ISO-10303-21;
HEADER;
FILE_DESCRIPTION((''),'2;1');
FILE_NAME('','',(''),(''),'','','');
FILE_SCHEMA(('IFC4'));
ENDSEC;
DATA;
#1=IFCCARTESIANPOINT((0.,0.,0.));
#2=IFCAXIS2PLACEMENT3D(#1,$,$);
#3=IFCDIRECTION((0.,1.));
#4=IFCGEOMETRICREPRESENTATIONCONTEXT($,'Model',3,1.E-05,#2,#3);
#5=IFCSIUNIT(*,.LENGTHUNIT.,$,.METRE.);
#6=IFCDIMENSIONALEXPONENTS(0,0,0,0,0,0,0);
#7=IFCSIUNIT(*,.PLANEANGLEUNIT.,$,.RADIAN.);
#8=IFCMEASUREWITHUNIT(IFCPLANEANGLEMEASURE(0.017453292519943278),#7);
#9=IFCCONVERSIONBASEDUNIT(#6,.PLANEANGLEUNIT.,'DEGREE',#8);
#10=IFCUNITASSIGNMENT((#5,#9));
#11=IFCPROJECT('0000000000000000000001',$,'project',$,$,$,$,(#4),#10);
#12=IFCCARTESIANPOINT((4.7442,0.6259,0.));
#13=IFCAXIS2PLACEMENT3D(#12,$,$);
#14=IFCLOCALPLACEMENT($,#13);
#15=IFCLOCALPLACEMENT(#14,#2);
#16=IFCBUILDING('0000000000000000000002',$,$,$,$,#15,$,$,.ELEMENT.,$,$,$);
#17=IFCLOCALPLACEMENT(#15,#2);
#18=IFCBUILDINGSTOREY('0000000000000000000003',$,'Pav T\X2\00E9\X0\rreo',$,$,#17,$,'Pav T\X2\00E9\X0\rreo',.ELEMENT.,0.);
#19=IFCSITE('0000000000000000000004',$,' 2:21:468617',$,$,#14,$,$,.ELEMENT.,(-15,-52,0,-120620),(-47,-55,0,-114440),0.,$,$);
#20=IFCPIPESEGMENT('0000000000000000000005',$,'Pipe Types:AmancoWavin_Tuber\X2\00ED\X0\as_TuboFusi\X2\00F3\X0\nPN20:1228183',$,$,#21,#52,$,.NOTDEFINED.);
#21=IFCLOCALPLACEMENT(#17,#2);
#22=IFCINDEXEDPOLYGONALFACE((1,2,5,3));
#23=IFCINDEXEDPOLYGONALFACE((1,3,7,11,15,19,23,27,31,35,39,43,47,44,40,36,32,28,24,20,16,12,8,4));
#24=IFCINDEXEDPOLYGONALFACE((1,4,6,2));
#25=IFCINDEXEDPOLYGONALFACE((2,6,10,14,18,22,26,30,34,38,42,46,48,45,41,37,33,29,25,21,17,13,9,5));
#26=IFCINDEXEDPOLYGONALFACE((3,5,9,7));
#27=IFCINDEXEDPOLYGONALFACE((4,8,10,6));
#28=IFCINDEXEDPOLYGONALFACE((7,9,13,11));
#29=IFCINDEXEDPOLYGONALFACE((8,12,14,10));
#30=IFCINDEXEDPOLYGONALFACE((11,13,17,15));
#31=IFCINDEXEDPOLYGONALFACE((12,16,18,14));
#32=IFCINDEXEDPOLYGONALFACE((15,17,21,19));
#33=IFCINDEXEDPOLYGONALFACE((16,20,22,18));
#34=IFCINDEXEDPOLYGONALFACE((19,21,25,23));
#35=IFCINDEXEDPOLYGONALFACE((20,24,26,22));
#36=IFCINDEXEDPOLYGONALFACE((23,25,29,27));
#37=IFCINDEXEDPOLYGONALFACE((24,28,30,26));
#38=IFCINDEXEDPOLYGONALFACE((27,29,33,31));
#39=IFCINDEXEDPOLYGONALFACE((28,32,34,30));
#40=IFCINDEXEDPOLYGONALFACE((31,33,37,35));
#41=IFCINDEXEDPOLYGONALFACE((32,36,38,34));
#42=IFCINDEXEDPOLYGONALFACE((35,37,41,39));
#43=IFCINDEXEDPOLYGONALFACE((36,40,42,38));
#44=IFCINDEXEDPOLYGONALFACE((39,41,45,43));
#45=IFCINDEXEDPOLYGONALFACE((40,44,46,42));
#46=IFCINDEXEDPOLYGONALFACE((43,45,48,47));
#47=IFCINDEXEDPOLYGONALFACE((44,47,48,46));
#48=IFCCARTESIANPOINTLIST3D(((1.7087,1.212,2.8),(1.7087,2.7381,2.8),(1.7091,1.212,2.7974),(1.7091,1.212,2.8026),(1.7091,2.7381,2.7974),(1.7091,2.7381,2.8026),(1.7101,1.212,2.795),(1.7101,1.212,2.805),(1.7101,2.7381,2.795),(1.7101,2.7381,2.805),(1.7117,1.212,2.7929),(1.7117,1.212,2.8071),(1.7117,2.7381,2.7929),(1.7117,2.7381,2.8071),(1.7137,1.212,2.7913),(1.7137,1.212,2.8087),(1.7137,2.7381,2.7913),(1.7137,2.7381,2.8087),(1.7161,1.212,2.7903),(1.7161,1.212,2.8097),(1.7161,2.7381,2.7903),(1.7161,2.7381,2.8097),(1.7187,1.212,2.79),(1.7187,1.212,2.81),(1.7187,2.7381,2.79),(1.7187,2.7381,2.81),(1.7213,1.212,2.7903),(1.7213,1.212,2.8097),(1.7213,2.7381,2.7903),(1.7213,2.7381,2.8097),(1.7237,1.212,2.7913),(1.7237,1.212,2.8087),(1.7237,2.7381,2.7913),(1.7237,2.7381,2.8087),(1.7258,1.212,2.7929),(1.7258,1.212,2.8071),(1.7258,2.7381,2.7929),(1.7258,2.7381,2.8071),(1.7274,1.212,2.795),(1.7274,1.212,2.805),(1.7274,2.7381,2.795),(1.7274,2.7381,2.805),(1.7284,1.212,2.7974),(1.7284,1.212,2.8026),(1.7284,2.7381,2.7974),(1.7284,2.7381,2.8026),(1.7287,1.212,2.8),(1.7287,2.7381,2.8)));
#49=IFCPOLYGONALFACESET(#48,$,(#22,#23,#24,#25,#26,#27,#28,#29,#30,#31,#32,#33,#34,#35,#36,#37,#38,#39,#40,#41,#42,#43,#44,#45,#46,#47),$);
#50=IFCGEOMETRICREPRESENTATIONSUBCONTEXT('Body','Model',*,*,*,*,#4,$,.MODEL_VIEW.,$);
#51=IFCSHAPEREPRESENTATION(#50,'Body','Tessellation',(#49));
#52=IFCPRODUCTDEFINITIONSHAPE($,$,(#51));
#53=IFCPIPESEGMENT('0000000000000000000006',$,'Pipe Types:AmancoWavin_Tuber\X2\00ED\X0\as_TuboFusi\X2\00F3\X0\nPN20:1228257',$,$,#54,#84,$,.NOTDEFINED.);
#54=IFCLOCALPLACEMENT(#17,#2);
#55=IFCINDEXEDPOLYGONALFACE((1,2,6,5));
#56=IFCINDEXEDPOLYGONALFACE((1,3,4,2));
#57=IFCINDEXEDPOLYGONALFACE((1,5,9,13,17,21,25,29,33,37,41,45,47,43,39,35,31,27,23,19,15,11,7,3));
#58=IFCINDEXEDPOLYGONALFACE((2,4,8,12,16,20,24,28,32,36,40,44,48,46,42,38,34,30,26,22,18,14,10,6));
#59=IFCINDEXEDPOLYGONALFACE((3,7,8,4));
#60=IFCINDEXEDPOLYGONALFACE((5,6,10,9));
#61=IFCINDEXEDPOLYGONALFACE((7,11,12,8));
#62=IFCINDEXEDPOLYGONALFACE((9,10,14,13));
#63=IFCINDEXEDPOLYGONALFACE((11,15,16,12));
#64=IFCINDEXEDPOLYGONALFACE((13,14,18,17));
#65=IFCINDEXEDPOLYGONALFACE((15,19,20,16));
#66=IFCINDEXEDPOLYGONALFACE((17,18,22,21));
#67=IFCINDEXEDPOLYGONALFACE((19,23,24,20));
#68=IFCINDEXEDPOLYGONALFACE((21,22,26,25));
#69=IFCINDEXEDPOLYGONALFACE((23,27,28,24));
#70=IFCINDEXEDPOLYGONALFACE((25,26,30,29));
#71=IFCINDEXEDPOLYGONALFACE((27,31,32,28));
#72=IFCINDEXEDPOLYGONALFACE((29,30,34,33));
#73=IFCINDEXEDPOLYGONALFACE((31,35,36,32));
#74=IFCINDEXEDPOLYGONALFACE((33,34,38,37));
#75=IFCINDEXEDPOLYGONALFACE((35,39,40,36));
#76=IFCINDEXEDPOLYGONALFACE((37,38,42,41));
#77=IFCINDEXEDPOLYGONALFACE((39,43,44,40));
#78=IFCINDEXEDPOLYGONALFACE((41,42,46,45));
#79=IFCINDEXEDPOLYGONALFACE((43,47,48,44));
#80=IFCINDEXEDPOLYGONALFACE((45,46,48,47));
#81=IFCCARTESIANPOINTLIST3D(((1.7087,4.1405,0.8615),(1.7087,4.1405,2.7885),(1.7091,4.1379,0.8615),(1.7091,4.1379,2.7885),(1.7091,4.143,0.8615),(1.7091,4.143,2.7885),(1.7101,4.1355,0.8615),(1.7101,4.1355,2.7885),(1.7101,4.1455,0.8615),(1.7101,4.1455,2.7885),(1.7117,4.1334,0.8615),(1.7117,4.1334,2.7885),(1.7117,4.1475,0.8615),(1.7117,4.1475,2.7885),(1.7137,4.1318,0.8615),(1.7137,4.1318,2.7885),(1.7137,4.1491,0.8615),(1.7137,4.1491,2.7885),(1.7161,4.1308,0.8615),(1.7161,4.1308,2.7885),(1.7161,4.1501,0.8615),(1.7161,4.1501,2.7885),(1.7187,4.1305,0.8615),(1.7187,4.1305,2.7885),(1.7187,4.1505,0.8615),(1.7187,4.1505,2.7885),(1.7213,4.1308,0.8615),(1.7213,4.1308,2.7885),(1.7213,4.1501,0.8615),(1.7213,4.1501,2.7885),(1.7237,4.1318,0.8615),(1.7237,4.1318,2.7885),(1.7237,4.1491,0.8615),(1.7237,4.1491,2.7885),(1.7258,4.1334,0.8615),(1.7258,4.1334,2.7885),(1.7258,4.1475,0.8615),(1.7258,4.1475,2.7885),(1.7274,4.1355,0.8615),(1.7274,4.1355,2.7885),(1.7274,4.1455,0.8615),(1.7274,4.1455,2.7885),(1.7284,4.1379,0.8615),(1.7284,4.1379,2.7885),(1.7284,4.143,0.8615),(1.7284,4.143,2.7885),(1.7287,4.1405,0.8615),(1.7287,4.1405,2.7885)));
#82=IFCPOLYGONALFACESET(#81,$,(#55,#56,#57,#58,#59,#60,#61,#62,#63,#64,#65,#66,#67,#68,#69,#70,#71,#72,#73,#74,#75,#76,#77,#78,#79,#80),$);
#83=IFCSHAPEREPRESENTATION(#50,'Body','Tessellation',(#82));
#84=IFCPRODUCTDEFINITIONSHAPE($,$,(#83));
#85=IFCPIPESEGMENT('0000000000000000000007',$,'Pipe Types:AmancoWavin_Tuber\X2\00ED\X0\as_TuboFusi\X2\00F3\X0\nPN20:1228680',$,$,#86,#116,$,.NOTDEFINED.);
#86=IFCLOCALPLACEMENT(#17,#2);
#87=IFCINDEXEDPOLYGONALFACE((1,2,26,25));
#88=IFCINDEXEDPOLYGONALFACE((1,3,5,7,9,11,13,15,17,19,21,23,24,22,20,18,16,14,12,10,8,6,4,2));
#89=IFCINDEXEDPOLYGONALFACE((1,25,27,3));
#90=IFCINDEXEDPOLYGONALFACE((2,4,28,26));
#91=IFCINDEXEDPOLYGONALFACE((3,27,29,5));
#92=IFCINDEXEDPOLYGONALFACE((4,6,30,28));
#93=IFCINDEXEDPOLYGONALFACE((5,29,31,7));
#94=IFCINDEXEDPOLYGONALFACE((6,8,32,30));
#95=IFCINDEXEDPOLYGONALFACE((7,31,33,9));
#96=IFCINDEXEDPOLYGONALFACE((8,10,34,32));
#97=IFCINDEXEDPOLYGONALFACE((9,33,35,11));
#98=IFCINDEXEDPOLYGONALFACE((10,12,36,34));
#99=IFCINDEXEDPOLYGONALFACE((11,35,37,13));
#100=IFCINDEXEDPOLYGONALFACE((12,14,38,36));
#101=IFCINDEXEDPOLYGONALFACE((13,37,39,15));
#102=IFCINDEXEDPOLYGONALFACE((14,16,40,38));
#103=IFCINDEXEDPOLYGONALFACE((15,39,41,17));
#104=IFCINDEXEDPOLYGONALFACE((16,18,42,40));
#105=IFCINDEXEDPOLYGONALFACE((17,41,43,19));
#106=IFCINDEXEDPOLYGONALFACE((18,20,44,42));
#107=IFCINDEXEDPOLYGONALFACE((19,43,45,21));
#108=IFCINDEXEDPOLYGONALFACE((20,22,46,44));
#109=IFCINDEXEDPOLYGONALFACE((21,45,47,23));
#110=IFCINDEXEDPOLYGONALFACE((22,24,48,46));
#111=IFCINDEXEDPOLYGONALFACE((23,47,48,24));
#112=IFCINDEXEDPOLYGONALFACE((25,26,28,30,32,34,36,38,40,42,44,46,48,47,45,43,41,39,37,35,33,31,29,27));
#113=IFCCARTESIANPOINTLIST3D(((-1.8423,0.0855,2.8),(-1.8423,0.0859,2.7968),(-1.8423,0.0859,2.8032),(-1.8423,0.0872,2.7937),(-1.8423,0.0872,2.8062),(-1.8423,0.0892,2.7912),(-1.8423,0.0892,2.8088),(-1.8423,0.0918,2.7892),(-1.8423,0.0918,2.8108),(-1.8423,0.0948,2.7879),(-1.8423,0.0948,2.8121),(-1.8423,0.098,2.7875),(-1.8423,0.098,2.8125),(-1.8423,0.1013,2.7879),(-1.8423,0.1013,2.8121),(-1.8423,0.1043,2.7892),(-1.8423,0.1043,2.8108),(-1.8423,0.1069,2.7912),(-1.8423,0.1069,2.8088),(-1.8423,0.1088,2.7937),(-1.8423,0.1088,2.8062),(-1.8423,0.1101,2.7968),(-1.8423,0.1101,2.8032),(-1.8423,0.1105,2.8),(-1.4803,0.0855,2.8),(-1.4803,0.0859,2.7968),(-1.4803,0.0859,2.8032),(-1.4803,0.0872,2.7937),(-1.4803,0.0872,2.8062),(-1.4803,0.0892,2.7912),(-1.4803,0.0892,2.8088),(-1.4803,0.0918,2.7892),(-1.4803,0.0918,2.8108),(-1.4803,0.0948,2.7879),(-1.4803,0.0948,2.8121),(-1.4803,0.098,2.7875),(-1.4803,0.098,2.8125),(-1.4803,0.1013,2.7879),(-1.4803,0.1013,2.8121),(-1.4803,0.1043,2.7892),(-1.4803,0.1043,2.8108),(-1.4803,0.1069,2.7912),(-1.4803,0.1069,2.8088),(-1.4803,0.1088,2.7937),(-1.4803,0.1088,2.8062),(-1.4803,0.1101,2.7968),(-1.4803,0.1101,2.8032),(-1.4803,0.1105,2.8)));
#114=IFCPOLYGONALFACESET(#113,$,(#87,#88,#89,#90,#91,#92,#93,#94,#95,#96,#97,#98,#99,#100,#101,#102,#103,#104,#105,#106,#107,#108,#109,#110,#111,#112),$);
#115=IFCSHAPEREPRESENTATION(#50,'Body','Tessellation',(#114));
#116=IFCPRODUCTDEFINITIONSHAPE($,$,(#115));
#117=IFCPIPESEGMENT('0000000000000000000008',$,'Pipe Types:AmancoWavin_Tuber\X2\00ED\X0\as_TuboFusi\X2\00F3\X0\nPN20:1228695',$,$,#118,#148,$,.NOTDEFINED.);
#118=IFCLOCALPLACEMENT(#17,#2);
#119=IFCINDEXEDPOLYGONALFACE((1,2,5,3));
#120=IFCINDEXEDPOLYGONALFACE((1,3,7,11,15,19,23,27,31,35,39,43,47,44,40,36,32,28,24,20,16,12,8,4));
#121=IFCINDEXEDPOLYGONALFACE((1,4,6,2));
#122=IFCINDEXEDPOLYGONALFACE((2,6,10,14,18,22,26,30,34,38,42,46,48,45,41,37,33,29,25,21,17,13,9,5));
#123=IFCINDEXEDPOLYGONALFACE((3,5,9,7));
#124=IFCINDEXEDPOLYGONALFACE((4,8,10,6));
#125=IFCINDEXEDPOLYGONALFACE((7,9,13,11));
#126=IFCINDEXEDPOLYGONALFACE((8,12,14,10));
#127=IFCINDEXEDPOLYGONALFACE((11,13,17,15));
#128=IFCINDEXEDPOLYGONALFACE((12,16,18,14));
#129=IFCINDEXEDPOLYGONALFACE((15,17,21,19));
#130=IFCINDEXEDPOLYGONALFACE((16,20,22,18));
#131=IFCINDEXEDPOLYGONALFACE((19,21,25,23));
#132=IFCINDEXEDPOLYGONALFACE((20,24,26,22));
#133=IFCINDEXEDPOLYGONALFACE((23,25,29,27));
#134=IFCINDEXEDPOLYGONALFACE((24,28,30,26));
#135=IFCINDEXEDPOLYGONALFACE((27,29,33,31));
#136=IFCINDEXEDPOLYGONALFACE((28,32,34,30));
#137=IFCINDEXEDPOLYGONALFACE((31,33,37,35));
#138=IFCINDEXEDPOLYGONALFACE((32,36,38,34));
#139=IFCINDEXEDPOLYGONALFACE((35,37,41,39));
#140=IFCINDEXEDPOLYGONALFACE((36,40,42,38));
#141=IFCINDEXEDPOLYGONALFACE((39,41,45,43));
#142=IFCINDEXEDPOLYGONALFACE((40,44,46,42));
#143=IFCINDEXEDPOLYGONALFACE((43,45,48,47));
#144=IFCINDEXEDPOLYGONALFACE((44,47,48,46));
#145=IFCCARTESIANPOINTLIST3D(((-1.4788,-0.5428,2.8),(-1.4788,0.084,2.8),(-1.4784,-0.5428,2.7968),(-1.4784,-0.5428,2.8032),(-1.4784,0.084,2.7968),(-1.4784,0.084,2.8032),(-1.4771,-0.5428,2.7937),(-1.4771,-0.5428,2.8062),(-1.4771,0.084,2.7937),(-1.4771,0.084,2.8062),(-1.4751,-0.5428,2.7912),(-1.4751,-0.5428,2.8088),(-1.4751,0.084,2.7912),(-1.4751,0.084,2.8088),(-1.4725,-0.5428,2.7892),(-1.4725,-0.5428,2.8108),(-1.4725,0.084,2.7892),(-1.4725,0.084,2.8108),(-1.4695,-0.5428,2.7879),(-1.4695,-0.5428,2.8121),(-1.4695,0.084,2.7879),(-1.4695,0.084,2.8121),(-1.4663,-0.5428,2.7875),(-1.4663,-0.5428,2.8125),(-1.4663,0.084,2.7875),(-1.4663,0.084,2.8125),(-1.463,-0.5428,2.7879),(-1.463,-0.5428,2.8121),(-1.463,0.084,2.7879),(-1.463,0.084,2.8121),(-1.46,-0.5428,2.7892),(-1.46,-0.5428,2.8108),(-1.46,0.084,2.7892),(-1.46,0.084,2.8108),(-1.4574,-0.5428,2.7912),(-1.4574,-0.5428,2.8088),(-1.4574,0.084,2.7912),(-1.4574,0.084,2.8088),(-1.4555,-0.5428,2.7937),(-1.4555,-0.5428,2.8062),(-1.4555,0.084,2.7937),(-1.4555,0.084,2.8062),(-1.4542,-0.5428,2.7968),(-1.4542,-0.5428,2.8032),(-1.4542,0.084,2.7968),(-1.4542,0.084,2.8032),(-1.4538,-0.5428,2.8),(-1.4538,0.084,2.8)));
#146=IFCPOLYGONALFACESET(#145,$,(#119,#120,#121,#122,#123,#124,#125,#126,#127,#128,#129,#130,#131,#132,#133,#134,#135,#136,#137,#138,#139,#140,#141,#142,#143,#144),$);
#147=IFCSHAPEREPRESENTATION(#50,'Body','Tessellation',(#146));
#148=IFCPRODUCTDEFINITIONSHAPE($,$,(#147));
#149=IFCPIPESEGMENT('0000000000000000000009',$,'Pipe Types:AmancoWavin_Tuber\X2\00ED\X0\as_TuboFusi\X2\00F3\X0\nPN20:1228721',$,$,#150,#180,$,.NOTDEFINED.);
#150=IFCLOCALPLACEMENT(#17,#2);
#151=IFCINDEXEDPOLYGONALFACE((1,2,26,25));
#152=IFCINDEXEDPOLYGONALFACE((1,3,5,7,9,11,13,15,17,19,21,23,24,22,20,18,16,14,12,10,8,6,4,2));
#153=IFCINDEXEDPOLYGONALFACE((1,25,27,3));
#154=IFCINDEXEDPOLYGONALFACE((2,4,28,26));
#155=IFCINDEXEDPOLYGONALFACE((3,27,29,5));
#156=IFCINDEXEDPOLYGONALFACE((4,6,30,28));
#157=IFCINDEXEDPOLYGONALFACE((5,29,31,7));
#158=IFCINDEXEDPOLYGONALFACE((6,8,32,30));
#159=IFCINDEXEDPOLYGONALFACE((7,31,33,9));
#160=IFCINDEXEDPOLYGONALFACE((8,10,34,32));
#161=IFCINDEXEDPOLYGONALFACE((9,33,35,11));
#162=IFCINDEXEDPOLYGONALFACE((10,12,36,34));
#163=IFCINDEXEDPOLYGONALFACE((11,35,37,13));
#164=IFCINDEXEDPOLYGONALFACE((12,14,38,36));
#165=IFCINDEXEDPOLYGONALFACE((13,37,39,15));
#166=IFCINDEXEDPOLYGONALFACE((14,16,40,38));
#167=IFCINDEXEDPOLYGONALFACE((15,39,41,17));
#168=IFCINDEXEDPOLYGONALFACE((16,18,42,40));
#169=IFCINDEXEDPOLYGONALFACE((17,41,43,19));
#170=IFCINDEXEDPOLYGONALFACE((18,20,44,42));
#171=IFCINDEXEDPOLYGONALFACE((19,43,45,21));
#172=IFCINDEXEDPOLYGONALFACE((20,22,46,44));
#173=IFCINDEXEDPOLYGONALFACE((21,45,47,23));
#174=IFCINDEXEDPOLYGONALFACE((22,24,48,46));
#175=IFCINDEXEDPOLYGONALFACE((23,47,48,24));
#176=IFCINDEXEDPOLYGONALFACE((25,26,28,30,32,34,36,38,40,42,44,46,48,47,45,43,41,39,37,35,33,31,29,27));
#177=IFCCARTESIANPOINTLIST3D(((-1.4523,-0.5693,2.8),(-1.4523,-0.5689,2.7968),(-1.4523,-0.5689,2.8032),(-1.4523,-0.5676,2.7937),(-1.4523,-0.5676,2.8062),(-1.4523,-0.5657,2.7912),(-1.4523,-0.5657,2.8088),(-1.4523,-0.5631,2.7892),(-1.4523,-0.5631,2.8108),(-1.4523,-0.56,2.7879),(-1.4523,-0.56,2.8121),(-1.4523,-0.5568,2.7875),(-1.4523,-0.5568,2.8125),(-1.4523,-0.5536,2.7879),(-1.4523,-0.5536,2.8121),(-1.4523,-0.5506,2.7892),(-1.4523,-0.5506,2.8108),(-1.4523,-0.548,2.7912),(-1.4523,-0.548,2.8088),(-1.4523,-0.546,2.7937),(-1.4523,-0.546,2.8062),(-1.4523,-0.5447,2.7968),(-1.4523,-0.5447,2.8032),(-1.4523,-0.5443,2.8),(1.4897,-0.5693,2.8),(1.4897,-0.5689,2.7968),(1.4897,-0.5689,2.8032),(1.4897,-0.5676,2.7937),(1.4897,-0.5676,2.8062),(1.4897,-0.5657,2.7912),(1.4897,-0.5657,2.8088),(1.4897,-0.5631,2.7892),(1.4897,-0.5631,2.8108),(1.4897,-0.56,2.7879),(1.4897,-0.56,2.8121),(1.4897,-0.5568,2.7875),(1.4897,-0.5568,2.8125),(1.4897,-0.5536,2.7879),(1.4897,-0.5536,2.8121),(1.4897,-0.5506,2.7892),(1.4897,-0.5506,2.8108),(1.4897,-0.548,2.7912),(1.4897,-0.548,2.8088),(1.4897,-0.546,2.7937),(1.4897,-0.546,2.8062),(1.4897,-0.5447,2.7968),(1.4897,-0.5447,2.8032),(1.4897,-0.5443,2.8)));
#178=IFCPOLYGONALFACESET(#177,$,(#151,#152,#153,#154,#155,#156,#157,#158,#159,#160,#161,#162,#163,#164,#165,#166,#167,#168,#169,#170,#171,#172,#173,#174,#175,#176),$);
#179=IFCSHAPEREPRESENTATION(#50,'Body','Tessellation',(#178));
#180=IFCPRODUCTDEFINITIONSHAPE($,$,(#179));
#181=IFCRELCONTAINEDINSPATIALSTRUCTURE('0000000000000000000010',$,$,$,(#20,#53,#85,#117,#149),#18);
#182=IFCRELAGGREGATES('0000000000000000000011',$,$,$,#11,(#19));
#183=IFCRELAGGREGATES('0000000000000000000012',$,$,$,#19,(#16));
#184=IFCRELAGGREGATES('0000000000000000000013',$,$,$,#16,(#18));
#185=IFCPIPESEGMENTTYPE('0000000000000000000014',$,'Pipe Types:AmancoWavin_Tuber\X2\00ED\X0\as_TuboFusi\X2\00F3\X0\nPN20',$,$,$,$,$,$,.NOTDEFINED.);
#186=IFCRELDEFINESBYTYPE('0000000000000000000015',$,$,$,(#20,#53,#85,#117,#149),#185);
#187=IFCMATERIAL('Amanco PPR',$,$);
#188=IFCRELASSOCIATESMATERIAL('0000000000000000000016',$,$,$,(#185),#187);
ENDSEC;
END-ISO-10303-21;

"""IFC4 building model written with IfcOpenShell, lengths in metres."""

from ifc_helpers import new_model, entity, si_unit, converted_unit, direction, frame, origin, place, context, subcontext, project, spatial, arc, indexed_curve, outline, extrude, material, type_object, element, save


model = new_model("IFC4")

# Units and contexts
model_context = context("Model", 3, precision=1e-05, world=origin(), true_north=direction((0.0, 1.0)))
body_context = subcontext(model_context, "Body", "Model", "MODEL_VIEW")
ifc_project = project(units=[si_unit("LENGTHUNIT", "METRE"), converted_unit("PLANEANGLEUNIT", "DEGREE", entity("IfcPlaneAngleMeasure", 0.017453292519943278), si_unit("PLANEANGLEUNIT", "RADIAN"), dimensions=[0, 0, 0, 0, 0, 0, 0])], contexts=[model_context])

# Site, building, storey
site_placement = place(None, frame((4.7442, 0.6259, 0.0)))
site = spatial("IfcSite", under=ifc_project, at=site_placement, Name=" 2:21:468617", CompositionType="ELEMENT", RefLatitude=(-15, -52, 0, -120620), RefLongitude=(-47, -55, 0, -114440), RefElevation=0.0)
building_placement = place(site_placement, origin())
building = spatial("IfcBuilding", under=site, at=building_placement, CompositionType="ELEMENT")
storey_placement = place(building_placement, origin())
storey = spatial("IfcBuildingStorey", under=building, at=storey_placement, Name="Pav Térreo", LongName="Pav Térreo", CompositionType="ELEMENT", Elevation=0.0)

# Pipe segments
ifc_material_1 = material(Name="Amanco PPR")
pipe_segment_type_1 = type_object("IfcPipeSegmentType", Name="Pipe Types:AmancoWavin_Tuberías_TuboFusiónPN20", PredefinedType="NOTDEFINED", material=ifc_material_1)
pipe_segment_1_placement = place(storey_placement, origin())
element("IfcPipeSegment", 1, at=pipe_segment_1_placement, inside=storey, type_object=pipe_segment_type_1, Name="Pipe Types:AmancoWavin_Tuberías_TuboFusiónPN20:1228183", PredefinedType="NOTDEFINED", context=body_context, shape_type="SweptSolid", body=[
    extrude(outline(indexed_curve([(0.01, 0.0), (0.0071, 0.0071), (0.0, 0.01), (-0.0071, 0.0071), (-0.01, 0.0), (-0.0071, -0.0071), (0.0, -0.01), (0.0071, -0.0071)], segments=[arc(1, 2, 3), arc(3, 4, 5), arc(5, 6, 7), arc(7, 8, 1)], self_intersect=False)), frame((1.7187, 1.212, 2.8), z_axis=(0.0, 1.0, 0.0), x_axis=(1.0, 0.0, 0.0)), (0.0, 0.0, 1.0), 1.5261),
])
pipe_segment_2_placement = place(storey_placement, origin())
element("IfcPipeSegment", 2, at=pipe_segment_2_placement, inside=storey, type_object=pipe_segment_type_1, Name="Pipe Types:AmancoWavin_Tuberías_TuboFusiónPN20:1228257", PredefinedType="NOTDEFINED", context=body_context, shape_type="SweptSolid", body=[
    extrude(outline(indexed_curve([(0.01, 0.0), (0.0071, 0.0071), (0.0, 0.01), (-0.0071, 0.0071), (-0.01, 0.0), (-0.0071, -0.0071), (0.0, -0.01), (0.0071, -0.0071)], segments=[arc(1, 2, 3), arc(3, 4, 5), arc(5, 6, 7), arc(7, 8, 1)], self_intersect=False)), frame((1.7187, 4.1405, 0.8615)), (0.0, 0.0, 1.0), 1.927),
])
pipe_segment_3_placement = place(storey_placement, origin())
element("IfcPipeSegment", 3, at=pipe_segment_3_placement, inside=storey, type_object=pipe_segment_type_1, Name="Pipe Types:AmancoWavin_Tuberías_TuboFusiónPN20:1228680", PredefinedType="NOTDEFINED", context=body_context, shape_type="SweptSolid", body=[
    extrude(outline(indexed_curve([(0.0125, 0.0), (0.0088, 0.0088), (0.0, 0.0125), (-0.0088, 0.0088), (-0.0125, 0.0), (-0.0088, -0.0088), (0.0, -0.0125), (0.0088, -0.0088)], segments=[arc(1, 2, 3), arc(3, 4, 5), arc(5, 6, 7), arc(7, 8, 1)], self_intersect=False)), frame((-1.8423, 0.098, 2.8), z_axis=(1.0, 0.0, 0.0), x_axis=(0.0, -1.0, 0.0)), (0.0, 0.0, 1.0), 0.362),
])
pipe_segment_4_placement = place(storey_placement, origin())
element("IfcPipeSegment", 4, at=pipe_segment_4_placement, inside=storey, type_object=pipe_segment_type_1, Name="Pipe Types:AmancoWavin_Tuberías_TuboFusiónPN20:1228695", PredefinedType="NOTDEFINED", context=body_context, shape_type="SweptSolid", body=[
    extrude(outline(indexed_curve([(0.0125, 0.0), (0.0088, 0.0088), (0.0, 0.0125), (-0.0088, 0.0088), (-0.0125, 0.0), (-0.0088, -0.0088), (0.0, -0.0125), (0.0088, -0.0088)], segments=[arc(1, 2, 3), arc(3, 4, 5), arc(5, 6, 7), arc(7, 8, 1)], self_intersect=False)), frame((-1.4663, -0.5428, 2.8), z_axis=(0.0, 1.0, 0.0), x_axis=(-1.0, 0.0, 0.0)), (0.0, 0.0, 1.0), 0.6268),
])
pipe_segment_5_placement = place(storey_placement, origin())
element("IfcPipeSegment", 5, at=pipe_segment_5_placement, inside=storey, type_object=pipe_segment_type_1, Name="Pipe Types:AmancoWavin_Tuberías_TuboFusiónPN20:1228721", PredefinedType="NOTDEFINED", context=body_context, shape_type="SweptSolid", body=[
    extrude(outline(indexed_curve([(0.0125, 0.0), (0.0088, 0.0088), (0.0, 0.0125), (-0.0088, 0.0088), (-0.0125, 0.0), (-0.0088, -0.0088), (0.0, -0.0125), (0.0088, -0.0088)], segments=[arc(1, 2, 3), arc(3, 4, 5), arc(5, 6, 7), arc(7, 8, 1)], self_intersect=False)), frame((-1.4523, -0.5568, 2.8), z_axis=(1.0, 0.0, 0.0), x_axis=(0.0, -1.0, 0.0)), (0.0, 0.0, 1.0), 2.942),
])

save(model, "model.ifc")
